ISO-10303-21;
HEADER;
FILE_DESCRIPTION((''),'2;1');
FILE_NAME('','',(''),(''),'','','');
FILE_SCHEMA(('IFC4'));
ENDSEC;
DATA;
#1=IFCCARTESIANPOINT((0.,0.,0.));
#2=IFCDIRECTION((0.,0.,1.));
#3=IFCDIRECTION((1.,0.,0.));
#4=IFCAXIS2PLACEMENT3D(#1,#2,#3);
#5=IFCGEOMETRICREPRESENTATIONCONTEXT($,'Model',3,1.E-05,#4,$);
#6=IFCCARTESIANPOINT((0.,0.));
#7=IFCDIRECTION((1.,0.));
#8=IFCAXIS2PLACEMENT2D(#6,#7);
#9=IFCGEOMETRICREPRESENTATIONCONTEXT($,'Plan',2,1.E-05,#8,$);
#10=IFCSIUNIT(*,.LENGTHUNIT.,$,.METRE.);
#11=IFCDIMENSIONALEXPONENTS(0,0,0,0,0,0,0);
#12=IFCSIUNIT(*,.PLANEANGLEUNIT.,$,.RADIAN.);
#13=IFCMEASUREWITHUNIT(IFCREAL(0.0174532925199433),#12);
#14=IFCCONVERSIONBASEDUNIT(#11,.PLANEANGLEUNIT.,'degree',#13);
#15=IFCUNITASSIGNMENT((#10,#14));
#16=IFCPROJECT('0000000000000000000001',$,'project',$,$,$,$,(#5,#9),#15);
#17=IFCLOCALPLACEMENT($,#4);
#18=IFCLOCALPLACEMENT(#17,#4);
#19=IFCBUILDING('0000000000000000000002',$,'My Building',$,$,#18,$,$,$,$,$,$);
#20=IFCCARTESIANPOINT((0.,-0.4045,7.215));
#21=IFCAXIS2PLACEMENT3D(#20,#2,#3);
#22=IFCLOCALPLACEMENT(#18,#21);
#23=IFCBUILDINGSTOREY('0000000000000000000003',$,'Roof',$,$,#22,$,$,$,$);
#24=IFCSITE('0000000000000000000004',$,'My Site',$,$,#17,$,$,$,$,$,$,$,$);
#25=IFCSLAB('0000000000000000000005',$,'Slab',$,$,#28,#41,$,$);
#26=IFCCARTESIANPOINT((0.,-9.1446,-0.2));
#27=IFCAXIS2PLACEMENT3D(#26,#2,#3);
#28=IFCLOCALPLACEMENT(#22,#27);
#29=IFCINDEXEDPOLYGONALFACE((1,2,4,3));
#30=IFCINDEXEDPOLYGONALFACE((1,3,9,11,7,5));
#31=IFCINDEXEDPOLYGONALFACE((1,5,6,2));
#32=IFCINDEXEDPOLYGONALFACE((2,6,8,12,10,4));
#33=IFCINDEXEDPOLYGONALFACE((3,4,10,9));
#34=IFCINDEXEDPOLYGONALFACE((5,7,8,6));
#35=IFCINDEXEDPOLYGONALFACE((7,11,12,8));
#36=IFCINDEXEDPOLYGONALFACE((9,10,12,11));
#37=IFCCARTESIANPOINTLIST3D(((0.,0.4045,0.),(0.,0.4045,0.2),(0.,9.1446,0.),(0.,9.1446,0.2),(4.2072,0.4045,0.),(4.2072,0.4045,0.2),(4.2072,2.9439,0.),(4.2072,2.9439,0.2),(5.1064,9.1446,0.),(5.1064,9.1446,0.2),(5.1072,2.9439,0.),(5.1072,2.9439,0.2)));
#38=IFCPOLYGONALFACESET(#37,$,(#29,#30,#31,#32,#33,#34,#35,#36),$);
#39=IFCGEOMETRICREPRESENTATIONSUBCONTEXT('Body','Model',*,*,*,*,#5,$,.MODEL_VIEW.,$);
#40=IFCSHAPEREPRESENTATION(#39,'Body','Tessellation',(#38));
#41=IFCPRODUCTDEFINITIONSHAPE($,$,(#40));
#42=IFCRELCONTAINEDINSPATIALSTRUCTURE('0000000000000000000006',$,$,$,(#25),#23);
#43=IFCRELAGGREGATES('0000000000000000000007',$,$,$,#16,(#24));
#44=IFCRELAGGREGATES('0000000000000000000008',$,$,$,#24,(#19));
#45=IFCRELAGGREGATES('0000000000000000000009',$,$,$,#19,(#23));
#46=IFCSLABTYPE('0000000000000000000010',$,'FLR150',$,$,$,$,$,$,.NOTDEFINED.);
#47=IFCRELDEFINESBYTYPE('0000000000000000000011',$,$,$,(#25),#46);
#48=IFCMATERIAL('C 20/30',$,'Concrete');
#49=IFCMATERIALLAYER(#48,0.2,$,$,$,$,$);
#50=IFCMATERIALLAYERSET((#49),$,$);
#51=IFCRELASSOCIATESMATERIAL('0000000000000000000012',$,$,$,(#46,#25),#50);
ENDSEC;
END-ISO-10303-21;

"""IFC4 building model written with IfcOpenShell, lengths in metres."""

from ifc_helpers import new_model, entity, si_unit, converted_unit, frame, origin_with_axes, origin_2d_with_axis, place, context, subcontext, project, spatial, line, indexed_curve, outline, extrude, material, layer, layer_set, layer_usage, type_object, element, save


model = new_model("IFC4")

# Units and contexts
model_context = context("Model", 3, precision=1e-05, world=origin_with_axes())
plan_context = context("Plan", 2, precision=1e-05, world=origin_2d_with_axis())
body_context = subcontext(model_context, "Body", "Model", "MODEL_VIEW")
ifc_project = project(units=[si_unit("LENGTHUNIT", "METRE"), converted_unit("PLANEANGLEUNIT", "degree", entity("IfcReal", 0.0174532925199433), si_unit("PLANEANGLEUNIT", "RADIAN"), dimensions=[0, 0, 0, 0, 0, 0, 0])], contexts=[model_context, plan_context])

# Site, building, storey
site_placement = place(None, origin_with_axes())
site = spatial("IfcSite", under=ifc_project, at=site_placement, Name="My Site")
building_placement = place(site_placement, origin_with_axes())
building = spatial("IfcBuilding", under=site, at=building_placement, Name="My Building")
storey_placement = place(building_placement, frame((0.0, -0.4045, 7.215), z_axis=(0.0, 0.0, 1.0), x_axis=(1.0, 0.0, 0.0)))
storey = spatial("IfcBuildingStorey", under=building, at=storey_placement, Name="Roof")

# Slab
ifc_material = material(Name="C 20/30", Category="Concrete")
ifc_layer = layer(ifc_material, 0.2)
ifc_layer_set = layer_set([ifc_layer])
ifc_layer_usage = layer_usage(ifc_layer_set, "AXIS3", "POSITIVE", 0.0)
slab_type = type_object("IfcSlabType", Name="FLR150", PredefinedType="NOTDEFINED", material=ifc_layer_set)
slab_placement = place(storey_placement, frame((0.0, -9.1446, -0.2), z_axis=(0.0, 0.0, 1.0), x_axis=(1.0, 0.0, 0.0)))
element("IfcSlab", 1, at=slab_placement, inside=storey, type_object=slab_type, material=ifc_layer_usage, Name="Slab", context=body_context, shape_type="SweptSolid", body=[
    extrude(outline(indexed_curve([(0.0, 9.1446), (5.1064, 9.1446), (5.1072, 2.9439), (4.2072, 2.9439), (4.2072, 0.4045), (0.0, 0.4045)], segments=[line(2, 1), line(1, 6), line(6, 5), line(5, 4), line(4, 3), line(3, 2)], self_intersect=False)), None, (0.0, 0.0, 1.0), 0.2),
])

save(model, "model.ifc")
